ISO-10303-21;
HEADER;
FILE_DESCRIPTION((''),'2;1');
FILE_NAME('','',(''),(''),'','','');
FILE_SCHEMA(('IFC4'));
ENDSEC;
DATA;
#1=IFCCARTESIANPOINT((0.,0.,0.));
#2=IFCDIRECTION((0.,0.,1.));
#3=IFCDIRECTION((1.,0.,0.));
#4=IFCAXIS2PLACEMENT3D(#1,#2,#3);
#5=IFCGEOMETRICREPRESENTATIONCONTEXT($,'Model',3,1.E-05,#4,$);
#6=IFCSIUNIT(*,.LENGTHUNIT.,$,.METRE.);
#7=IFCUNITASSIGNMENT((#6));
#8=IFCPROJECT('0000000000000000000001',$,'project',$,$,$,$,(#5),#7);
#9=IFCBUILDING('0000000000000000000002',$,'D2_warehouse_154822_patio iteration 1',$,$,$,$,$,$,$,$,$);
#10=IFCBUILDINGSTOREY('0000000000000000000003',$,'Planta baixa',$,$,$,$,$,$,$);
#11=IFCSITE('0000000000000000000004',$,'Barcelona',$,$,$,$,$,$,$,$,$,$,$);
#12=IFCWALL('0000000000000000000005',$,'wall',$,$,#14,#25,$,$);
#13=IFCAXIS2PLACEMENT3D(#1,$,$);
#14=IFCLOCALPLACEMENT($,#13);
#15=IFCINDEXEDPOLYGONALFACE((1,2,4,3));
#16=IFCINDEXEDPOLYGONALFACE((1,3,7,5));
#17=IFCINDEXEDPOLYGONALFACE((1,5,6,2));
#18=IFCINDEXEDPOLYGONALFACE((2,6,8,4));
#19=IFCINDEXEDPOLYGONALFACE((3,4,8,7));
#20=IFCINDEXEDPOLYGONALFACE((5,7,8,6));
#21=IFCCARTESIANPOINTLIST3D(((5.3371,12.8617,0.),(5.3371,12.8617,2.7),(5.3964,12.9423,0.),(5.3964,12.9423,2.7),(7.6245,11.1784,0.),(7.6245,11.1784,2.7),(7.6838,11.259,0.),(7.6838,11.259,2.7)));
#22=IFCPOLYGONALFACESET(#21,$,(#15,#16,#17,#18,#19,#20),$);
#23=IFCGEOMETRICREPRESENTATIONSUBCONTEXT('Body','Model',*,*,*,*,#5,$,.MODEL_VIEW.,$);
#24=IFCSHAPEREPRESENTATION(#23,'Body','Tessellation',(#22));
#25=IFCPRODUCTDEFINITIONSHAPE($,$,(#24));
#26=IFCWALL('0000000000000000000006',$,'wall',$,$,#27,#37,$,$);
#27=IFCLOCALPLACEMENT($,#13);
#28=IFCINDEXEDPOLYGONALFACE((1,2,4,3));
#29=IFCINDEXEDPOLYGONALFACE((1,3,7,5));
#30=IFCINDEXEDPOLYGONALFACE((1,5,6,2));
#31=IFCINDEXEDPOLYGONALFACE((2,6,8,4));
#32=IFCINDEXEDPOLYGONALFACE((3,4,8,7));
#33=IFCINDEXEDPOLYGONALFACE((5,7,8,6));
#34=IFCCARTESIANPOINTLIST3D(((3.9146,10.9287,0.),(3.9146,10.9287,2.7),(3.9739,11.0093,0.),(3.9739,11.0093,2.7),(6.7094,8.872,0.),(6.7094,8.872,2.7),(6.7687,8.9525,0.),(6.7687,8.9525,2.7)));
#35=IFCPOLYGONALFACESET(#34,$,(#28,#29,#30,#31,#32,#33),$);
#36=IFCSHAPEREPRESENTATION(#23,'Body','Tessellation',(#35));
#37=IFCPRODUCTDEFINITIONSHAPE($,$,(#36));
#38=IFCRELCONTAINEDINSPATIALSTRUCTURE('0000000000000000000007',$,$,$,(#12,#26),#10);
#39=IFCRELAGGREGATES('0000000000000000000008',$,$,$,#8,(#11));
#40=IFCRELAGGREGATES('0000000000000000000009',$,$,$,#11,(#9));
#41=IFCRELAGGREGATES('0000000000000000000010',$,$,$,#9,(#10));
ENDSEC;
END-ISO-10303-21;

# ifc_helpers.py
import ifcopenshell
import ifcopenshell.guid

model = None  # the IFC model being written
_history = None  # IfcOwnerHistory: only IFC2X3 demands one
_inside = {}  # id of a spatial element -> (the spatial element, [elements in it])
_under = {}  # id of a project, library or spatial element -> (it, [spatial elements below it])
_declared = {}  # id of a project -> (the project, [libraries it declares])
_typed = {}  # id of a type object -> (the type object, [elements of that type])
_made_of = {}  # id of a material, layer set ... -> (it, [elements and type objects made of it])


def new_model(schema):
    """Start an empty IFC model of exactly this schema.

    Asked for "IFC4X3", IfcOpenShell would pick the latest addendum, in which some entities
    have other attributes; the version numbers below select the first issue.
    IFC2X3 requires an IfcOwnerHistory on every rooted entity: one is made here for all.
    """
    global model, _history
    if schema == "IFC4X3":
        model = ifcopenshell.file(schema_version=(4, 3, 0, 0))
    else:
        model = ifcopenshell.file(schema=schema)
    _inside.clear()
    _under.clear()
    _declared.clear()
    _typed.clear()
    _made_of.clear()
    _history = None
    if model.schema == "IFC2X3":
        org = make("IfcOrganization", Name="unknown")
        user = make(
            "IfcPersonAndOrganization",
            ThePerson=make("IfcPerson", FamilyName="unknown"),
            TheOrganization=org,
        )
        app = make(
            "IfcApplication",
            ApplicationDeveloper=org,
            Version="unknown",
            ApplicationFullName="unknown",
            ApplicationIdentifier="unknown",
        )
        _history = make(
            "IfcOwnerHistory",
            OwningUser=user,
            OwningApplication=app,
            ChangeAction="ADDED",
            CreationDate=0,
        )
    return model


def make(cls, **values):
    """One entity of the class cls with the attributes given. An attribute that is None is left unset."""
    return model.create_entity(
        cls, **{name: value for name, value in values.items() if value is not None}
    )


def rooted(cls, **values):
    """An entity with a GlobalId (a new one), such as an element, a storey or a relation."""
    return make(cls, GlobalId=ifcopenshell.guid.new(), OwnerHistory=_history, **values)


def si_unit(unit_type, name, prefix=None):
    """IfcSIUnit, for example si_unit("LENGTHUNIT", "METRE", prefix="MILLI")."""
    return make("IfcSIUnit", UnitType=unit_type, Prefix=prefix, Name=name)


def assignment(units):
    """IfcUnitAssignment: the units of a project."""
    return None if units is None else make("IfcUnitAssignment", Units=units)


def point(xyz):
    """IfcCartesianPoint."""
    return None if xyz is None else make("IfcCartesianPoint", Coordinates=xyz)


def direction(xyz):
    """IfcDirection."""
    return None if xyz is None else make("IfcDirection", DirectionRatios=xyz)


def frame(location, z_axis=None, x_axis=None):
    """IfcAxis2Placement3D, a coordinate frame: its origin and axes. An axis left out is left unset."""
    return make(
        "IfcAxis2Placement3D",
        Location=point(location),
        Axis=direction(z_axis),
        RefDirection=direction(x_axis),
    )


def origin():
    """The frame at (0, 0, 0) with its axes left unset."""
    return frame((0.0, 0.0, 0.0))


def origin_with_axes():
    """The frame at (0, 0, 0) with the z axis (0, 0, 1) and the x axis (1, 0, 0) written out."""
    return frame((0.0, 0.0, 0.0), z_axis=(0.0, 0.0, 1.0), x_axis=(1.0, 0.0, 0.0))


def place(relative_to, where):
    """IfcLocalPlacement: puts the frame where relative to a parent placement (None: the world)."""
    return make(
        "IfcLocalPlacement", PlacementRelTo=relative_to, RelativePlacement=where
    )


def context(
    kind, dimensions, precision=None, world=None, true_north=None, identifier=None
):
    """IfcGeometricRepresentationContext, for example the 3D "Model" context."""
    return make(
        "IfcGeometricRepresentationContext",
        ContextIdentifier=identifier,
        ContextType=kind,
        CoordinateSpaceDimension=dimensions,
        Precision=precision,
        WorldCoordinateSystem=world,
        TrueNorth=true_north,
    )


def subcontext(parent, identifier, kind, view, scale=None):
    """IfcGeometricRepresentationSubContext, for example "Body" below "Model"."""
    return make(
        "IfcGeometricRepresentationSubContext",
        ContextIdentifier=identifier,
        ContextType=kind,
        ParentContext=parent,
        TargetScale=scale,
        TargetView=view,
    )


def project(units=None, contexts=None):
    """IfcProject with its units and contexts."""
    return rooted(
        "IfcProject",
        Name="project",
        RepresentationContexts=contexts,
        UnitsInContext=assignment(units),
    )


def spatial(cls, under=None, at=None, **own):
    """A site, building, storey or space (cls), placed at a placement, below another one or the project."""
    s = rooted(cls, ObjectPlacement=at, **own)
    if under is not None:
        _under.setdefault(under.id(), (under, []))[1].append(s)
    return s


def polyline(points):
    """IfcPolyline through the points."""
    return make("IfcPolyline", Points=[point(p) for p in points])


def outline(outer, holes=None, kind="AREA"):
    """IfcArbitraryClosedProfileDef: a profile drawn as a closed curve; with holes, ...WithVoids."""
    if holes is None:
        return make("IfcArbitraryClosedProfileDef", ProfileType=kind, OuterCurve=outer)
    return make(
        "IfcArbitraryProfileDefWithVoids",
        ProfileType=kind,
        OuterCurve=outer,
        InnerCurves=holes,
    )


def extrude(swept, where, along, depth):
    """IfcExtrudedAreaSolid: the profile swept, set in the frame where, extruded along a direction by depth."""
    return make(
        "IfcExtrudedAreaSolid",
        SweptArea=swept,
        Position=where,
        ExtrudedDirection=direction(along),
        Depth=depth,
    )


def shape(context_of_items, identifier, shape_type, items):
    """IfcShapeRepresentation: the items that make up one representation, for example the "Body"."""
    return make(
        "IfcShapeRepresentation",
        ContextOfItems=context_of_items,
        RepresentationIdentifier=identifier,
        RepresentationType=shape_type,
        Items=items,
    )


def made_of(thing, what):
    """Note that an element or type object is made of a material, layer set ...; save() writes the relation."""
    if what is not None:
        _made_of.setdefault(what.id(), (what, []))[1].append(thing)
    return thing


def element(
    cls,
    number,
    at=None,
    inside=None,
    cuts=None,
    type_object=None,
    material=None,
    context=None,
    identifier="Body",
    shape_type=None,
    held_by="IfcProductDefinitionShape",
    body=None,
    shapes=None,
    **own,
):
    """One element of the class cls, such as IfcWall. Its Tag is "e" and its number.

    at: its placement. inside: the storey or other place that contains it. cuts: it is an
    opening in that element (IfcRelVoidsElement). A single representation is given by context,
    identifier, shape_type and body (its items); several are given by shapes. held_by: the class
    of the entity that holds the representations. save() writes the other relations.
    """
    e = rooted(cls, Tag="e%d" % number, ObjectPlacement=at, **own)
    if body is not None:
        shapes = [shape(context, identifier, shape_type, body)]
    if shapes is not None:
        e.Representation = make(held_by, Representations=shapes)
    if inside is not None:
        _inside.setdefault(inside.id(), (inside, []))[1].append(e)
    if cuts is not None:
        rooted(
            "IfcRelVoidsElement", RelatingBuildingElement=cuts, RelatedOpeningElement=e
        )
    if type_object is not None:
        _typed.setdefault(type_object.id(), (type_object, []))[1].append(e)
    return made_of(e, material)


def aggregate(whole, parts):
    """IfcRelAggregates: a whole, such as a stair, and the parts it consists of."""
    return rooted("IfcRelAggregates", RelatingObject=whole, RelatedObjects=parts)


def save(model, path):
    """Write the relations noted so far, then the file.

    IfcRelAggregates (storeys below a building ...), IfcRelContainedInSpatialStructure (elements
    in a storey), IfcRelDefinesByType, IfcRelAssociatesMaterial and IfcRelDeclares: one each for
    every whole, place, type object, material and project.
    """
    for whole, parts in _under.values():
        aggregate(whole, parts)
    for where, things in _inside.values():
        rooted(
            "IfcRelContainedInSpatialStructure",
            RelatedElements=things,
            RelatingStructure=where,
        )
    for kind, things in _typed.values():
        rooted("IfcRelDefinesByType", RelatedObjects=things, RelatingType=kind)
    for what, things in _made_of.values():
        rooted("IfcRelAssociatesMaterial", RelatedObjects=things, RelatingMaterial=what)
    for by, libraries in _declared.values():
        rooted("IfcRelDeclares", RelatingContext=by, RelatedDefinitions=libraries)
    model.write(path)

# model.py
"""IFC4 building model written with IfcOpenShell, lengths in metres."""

from ifc_helpers import new_model, si_unit, origin, origin_with_axes, place, context, subcontext, project, spatial, polyline, outline, extrude, element, save


model = new_model("IFC4")

# Units and contexts
model_context = context("Model", 3, precision=1e-05, world=origin_with_axes())
body_context = subcontext(model_context, "Body", "Model", "MODEL_VIEW")
ifc_project = project(units=[si_unit("LENGTHUNIT", "METRE")], contexts=[model_context])

# Site, building, storey
site = spatial("IfcSite", under=ifc_project, Name="Barcelona")
building = spatial("IfcBuilding", under=site, Name="D2_warehouse_154822_patio iteration 1")
storey = spatial("IfcBuildingStorey", under=building, Name="Planta baixa")

# Walls
wall_1_placement = place(None, origin_with_axes())
element("IfcWall", 1, at=wall_1_placement, inside=storey, Name="wall", context=body_context, shape_type="SweptSolid", body=[
    extrude(outline(polyline([(7.6245, 11.1784), (5.3371, 12.8617), (5.3964, 12.9423), (7.6838, 11.259), (7.6245, 11.1784)])), origin(), (0.0, 0.0, 1.0), 2.7),
])
wall_2_placement = place(None, origin_with_axes())
element("IfcWall", 2, at=wall_2_placement, inside=storey, Name="wall", context=body_context, shape_type="SweptSolid", body=[
    extrude(outline(polyline([(3.9739, 11.0093), (6.7687, 8.9525), (6.7094, 8.872), (3.9146, 10.9287), (3.9739, 11.0093)])), origin(), (0.0, 0.0, 1.0), 2.7),
])

save(model, "model.ifc")
